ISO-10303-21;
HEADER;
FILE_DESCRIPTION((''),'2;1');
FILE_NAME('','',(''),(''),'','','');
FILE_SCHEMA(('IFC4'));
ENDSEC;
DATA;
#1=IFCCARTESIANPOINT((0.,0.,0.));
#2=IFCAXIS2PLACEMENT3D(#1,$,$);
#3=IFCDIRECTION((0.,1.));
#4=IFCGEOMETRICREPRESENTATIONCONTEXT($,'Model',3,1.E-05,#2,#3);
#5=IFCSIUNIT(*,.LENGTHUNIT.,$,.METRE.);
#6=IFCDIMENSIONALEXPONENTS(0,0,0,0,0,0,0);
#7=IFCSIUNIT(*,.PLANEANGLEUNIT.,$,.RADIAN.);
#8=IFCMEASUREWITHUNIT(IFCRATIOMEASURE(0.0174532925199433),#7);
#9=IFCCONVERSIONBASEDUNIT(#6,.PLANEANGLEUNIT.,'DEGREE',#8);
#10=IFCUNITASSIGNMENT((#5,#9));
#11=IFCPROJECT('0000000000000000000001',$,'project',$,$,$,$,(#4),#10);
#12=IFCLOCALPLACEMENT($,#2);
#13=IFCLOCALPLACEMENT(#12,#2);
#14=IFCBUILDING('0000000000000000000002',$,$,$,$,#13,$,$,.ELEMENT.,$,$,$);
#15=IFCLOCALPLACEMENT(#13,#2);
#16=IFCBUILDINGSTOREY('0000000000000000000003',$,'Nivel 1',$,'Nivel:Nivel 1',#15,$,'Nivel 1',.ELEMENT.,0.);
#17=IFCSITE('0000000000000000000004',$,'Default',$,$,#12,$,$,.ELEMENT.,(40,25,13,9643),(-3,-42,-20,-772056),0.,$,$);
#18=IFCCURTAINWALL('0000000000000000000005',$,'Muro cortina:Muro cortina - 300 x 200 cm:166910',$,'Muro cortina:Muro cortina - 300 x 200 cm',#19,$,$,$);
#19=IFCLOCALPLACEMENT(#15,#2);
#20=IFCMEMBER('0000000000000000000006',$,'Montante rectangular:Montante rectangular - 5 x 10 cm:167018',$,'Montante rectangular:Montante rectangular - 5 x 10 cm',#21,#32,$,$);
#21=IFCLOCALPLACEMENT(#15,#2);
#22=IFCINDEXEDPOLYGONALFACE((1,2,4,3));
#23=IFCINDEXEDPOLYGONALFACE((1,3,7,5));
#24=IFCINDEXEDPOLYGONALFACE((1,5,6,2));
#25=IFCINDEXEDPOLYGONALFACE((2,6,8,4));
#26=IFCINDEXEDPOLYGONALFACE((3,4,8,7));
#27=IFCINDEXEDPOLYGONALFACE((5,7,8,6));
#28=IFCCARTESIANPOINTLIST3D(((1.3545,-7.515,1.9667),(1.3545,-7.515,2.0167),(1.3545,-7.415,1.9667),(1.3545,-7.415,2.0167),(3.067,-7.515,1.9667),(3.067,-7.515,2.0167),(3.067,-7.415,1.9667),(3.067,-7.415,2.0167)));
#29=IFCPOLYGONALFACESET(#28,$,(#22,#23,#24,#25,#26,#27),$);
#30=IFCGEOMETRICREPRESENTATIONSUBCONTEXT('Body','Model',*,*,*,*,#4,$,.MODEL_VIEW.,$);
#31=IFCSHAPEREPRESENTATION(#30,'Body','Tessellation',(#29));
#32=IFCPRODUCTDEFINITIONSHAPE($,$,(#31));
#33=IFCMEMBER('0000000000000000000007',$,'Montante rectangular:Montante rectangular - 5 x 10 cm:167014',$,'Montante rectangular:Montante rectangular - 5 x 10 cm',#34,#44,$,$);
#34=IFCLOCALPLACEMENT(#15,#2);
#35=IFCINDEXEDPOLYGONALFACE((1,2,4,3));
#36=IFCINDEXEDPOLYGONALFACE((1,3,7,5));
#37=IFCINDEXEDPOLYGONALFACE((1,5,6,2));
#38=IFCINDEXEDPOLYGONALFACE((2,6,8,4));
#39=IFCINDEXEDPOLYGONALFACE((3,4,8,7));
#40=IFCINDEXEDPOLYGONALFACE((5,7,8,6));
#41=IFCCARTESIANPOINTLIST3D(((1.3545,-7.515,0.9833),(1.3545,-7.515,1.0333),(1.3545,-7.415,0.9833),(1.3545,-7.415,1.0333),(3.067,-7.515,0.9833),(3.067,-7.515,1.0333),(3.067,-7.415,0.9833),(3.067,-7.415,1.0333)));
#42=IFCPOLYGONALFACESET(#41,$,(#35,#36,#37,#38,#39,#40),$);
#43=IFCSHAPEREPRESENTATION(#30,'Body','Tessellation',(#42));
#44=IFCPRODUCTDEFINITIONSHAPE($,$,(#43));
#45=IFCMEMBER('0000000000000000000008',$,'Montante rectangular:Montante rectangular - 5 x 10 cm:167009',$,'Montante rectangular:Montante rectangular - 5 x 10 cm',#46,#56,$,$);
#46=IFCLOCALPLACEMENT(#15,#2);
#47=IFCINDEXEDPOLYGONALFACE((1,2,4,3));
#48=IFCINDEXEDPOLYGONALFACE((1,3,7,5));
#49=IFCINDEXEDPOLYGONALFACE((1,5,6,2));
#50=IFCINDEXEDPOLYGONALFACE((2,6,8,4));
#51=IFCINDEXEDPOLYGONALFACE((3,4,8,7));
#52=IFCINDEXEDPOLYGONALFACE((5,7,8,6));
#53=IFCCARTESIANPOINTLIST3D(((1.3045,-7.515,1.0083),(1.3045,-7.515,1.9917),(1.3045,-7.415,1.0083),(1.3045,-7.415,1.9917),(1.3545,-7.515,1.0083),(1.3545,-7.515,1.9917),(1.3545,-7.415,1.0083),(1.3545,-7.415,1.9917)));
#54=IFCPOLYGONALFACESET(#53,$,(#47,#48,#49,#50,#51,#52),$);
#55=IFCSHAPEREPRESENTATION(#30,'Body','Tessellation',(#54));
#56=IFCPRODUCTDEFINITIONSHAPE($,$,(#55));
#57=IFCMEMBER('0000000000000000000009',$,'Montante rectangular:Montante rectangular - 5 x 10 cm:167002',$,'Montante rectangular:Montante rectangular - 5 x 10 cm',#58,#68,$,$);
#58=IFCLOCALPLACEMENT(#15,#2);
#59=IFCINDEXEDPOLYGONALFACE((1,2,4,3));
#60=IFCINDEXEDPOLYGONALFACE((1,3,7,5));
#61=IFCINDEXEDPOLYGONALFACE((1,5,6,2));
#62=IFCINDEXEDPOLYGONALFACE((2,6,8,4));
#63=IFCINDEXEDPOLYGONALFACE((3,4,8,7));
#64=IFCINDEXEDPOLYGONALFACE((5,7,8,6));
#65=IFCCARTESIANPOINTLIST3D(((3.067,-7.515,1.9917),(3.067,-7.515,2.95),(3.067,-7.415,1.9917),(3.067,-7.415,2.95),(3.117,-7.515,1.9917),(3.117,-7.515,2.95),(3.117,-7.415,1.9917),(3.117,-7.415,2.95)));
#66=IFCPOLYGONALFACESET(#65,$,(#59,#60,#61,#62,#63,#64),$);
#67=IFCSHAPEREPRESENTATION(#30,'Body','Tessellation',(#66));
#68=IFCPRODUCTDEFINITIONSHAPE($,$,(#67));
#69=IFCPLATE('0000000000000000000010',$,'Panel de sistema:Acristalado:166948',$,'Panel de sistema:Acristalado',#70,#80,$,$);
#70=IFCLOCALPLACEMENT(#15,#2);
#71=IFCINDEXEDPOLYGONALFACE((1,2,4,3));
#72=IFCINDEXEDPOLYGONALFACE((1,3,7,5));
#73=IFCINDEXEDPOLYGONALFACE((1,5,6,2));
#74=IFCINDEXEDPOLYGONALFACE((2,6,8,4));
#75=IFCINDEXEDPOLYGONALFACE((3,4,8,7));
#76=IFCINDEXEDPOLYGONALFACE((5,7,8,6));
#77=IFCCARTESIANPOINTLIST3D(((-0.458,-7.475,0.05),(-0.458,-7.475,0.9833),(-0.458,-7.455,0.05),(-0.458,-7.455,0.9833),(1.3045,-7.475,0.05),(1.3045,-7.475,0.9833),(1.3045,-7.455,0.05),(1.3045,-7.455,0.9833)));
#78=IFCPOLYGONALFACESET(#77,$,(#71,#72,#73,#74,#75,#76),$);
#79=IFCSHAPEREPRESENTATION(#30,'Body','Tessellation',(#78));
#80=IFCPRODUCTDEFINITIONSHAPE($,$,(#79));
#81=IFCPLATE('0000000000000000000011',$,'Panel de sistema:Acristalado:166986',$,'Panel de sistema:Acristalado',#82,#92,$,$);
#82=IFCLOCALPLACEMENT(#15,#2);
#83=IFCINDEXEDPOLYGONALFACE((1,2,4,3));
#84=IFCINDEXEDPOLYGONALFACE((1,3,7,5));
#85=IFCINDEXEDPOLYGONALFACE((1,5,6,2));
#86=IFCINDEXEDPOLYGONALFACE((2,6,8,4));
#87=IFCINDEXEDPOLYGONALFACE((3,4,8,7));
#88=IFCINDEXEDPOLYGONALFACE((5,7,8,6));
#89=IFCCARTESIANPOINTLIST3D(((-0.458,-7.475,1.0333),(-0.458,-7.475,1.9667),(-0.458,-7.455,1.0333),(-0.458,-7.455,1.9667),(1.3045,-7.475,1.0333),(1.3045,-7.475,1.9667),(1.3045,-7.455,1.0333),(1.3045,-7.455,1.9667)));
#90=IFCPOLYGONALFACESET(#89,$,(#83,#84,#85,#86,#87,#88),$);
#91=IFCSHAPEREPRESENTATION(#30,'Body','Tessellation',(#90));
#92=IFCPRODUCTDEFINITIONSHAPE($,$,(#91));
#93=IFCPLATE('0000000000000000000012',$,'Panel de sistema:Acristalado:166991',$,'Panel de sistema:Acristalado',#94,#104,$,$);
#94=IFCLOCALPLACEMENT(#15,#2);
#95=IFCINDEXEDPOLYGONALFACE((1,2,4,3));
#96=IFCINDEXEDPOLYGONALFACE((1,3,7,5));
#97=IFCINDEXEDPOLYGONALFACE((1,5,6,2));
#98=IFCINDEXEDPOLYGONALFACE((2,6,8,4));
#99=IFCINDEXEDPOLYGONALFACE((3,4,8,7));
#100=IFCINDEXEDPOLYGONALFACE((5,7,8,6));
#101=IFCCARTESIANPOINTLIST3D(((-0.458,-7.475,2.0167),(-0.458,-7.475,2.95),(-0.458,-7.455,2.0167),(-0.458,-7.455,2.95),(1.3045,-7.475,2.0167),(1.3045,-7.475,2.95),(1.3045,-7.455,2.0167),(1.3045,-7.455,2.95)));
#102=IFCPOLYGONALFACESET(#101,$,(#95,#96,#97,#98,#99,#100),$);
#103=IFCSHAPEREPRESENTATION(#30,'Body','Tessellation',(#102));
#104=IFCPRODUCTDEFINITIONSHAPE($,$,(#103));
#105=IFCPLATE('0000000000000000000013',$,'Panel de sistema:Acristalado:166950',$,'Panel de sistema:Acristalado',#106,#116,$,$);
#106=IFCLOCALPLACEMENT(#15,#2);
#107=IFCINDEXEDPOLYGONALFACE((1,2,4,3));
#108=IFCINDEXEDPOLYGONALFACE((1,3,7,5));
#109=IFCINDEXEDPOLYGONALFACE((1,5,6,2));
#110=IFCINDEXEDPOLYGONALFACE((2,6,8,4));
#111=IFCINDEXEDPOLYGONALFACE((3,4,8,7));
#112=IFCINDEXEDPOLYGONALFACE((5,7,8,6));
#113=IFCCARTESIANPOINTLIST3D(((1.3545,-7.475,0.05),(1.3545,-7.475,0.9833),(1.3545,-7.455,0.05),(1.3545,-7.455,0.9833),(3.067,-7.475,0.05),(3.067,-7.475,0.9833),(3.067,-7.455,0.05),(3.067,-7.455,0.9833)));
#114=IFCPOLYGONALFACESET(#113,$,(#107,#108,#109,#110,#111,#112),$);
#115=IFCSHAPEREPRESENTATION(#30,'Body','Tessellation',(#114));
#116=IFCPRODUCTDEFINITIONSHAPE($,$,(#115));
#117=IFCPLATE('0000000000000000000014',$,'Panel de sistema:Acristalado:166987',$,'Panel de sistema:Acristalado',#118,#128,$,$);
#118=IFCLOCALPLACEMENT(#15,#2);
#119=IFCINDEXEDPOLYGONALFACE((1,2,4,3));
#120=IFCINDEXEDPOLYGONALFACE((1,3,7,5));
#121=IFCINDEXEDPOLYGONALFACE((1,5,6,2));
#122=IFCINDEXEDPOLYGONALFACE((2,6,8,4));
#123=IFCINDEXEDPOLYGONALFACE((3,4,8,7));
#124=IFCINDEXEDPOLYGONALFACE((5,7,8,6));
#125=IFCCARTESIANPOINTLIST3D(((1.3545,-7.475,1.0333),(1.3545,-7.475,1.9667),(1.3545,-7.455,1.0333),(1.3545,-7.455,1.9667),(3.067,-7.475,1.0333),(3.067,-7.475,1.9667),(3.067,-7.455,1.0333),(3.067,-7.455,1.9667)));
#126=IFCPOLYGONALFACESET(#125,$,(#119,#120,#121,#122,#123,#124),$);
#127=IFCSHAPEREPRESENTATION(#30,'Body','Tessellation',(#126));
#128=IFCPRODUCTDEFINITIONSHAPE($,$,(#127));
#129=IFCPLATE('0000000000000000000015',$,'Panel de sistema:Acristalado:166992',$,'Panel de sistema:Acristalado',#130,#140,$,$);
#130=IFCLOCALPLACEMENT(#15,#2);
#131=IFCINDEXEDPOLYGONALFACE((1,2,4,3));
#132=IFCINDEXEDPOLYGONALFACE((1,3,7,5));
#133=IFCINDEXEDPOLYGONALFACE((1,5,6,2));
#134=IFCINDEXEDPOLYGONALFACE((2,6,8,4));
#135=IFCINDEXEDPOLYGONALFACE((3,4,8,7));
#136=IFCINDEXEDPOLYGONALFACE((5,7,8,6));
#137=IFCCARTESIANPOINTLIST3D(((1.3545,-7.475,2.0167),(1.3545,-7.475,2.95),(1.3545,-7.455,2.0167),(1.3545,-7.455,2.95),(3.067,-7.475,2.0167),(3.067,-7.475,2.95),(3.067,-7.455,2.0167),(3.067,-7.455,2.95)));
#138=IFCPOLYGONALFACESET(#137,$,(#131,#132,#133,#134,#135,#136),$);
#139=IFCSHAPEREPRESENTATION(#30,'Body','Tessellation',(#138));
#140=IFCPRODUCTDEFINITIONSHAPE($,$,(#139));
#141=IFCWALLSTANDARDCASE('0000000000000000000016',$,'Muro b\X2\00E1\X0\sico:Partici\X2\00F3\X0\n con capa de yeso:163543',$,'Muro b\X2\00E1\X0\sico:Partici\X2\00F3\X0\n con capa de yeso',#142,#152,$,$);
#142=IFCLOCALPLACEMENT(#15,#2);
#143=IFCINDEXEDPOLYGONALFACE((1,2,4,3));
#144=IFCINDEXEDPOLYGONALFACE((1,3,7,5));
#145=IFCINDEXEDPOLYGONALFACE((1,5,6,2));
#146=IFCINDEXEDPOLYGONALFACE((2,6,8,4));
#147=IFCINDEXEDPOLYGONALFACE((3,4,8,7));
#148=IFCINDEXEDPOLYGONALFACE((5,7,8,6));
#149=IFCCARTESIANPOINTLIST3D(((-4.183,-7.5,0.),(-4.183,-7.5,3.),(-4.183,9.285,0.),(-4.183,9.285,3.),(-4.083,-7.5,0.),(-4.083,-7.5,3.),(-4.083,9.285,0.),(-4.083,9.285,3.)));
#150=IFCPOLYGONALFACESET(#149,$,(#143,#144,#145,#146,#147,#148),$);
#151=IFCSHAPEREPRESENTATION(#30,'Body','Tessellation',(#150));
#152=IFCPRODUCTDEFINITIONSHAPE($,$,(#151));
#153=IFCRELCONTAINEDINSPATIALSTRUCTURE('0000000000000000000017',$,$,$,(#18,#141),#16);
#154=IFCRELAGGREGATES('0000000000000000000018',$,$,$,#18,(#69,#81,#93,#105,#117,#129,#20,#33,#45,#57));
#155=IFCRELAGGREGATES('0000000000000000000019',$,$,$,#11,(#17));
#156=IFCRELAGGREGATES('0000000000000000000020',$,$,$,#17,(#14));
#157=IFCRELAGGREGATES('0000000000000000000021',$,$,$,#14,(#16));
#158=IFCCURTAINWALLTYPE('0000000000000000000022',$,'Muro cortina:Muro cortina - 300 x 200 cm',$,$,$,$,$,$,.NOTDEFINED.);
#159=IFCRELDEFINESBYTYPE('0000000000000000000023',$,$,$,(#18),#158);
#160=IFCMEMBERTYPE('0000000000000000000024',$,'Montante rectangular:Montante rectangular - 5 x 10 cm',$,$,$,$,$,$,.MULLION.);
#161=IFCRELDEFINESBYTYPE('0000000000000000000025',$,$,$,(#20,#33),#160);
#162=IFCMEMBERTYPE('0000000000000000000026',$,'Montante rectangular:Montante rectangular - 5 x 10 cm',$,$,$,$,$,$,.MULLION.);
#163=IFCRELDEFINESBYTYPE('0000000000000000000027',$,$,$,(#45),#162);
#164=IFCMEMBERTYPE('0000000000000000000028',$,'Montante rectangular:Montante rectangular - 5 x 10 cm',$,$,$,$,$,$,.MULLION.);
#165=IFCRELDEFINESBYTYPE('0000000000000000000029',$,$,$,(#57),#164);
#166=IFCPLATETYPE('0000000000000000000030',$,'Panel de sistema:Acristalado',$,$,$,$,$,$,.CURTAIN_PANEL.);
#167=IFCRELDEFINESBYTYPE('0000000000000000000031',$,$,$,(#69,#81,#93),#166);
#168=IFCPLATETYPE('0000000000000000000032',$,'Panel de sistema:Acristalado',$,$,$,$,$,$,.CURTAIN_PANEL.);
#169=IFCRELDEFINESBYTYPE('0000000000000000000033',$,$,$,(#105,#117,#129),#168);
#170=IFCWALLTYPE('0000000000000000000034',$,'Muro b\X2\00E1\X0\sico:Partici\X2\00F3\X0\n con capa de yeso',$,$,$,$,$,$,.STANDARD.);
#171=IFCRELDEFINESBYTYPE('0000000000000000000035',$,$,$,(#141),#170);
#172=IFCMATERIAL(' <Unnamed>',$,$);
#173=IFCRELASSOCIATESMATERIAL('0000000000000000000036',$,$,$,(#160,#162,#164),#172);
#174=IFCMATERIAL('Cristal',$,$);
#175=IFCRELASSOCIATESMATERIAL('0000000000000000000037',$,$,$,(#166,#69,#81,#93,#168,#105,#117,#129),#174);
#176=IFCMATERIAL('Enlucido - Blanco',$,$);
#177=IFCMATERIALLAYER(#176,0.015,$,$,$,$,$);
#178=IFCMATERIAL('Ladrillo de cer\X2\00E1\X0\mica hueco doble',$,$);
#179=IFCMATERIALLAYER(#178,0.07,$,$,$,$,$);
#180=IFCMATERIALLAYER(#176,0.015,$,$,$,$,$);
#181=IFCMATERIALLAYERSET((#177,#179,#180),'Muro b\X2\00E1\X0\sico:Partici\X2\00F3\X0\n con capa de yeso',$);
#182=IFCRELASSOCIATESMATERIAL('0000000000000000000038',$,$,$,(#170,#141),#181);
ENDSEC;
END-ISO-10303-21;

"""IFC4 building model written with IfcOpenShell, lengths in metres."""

from ifc_helpers import new_model, entity, si_unit, converted_unit, direction, frame, frame_2d, origin, origin_2d_with_axis, place, context, subcontext, project, spatial, rectangle, extrude, source, transform, mapped, material, layer, layer_set, layer_usage, type_object, type_shapes, element, aggregate, save


model = new_model("IFC4")

# Units and contexts
model_context = context("Model", 3, precision=1e-05, world=origin(), true_north=direction((0.0, 1.0)))
body_context = subcontext(model_context, "Body", "Model", "MODEL_VIEW")
ifc_project = project(units=[si_unit("LENGTHUNIT", "METRE"), converted_unit("PLANEANGLEUNIT", "DEGREE", entity("IfcRatioMeasure", 0.0174532925199433), si_unit("PLANEANGLEUNIT", "RADIAN"), dimensions=[0, 0, 0, 0, 0, 0, 0])], contexts=[model_context])

# Site, building, storey
site_placement = place(None, origin())
site = spatial("IfcSite", under=ifc_project, at=site_placement, Name="Default", CompositionType="ELEMENT", RefLatitude=(40, 25, 13, 9643), RefLongitude=(-3, -42, -20, -772056), RefElevation=0.0)
building_placement = place(site_placement, origin())
building = spatial("IfcBuilding", under=site, at=building_placement, CompositionType="ELEMENT")
storey_placement = place(building_placement, origin())
storey = spatial("IfcBuildingStorey", under=building, at=storey_placement, Name="Nivel 1", ObjectType="Nivel:Nivel 1", LongName="Nivel 1", CompositionType="ELEMENT", Elevation=0.0)

# Curtain wall, members, plates
curtain_wall_type = type_object("IfcCurtainWallType", Name="Muro cortina:Muro cortina - 300 x 200 cm", PredefinedType="NOTDEFINED")
curtain_wall_placement = place(storey_placement, origin())
curtain_wall = element("IfcCurtainWall", 1, at=curtain_wall_placement, inside=storey, type_object=curtain_wall_type, Name="Muro cortina:Muro cortina - 300 x 200 cm:166910", ObjectType="Muro cortina:Muro cortina - 300 x 200 cm")
ifc_material_1 = material(Name=" <Unnamed>")
member_type_1 = type_object("IfcMemberType", Name="Montante rectangular:Montante rectangular - 5 x 10 cm", PredefinedType="MULLION", material=ifc_material_1)
shared_shape_1 = source(origin(), body_context, "Body", "SweptSolid", [
    extrude(rectangle(XDim=0.1, YDim=0.05, at=origin_2d_with_axis()), frame((0.0, 0.0, -1.7125), z_axis=(0.0, 0.0, 1.0), x_axis=(0.0, -1.0, 0.0)), (0.0, 0.0, 1.0), 1.7125),
])
type_shapes(member_type_1, [shared_shape_1])
member_1_placement = place(storey_placement, frame((3.067, -7.465, 1.9917), z_axis=(1.0, 0.0, 0.0), x_axis=(0.0, 0.0, 1.0)))
member_1 = element("IfcMember", 2, at=member_1_placement, type_object=member_type_1, Name="Montante rectangular:Montante rectangular - 5 x 10 cm:167018", ObjectType="Montante rectangular:Montante rectangular - 5 x 10 cm", context=body_context, shape_type="MappedRepresentation", body=[
    mapped(shared_shape_1, transform((0.0, 0.0, 0.0), scale=1.0)),
])
member_2_placement = place(storey_placement, frame((3.067, -7.465, 1.0083), z_axis=(1.0, 0.0, 0.0), x_axis=(0.0, 0.0, 1.0)))
member_2 = element("IfcMember", 3, at=member_2_placement, type_object=member_type_1, Name="Montante rectangular:Montante rectangular - 5 x 10 cm:167014", ObjectType="Montante rectangular:Montante rectangular - 5 x 10 cm", context=body_context, shape_type="MappedRepresentation", body=[
    mapped(shared_shape_1, transform((0.0, 0.0, 0.0), scale=1.0)),
])
member_type_2 = type_object("IfcMemberType", Name="Montante rectangular:Montante rectangular - 5 x 10 cm", PredefinedType="MULLION", material=ifc_material_1)
shared_shape_2 = source(origin(), body_context, "Body", "SweptSolid", [
    extrude(rectangle(XDim=0.1, YDim=0.05, at=origin_2d_with_axis()), frame((0.0, 0.0, -0.9833), z_axis=(0.0, 0.0, 1.0), x_axis=(0.0, -1.0, 0.0)), (0.0, 0.0, 1.0), 0.9833),
])
type_shapes(member_type_2, [shared_shape_2])
member_3_placement = place(storey_placement, frame((1.3295, -7.465, 1.0083), z_axis=(0.0, 0.0, -1.0), x_axis=(1.0, 0.0, 0.0)))
member_3 = element("IfcMember", 4, at=member_3_placement, type_object=member_type_2, Name="Montante rectangular:Montante rectangular - 5 x 10 cm:167009", ObjectType="Montante rectangular:Montante rectangular - 5 x 10 cm", context=body_context, shape_type="MappedRepresentation", body=[
    mapped(shared_shape_2, transform((0.0, 0.0, 0.0), scale=1.0)),
])
member_type_3 = type_object("IfcMemberType", Name="Montante rectangular:Montante rectangular - 5 x 10 cm", PredefinedType="MULLION", material=ifc_material_1)
shared_shape_3 = source(origin(), body_context, "Body", "SweptSolid", [
    extrude(rectangle(XDim=0.1, YDim=0.05, at=origin_2d_with_axis()), frame((-0.025, 0.0, -0.9583), z_axis=(0.0, 0.0, 1.0), x_axis=(0.0, -1.0, 0.0)), (0.0, 0.0, 1.0), 0.9583),
])
type_shapes(member_type_3, [shared_shape_3])
member_4_placement = place(storey_placement, frame((3.117, -7.465, 1.9917), z_axis=(0.0, 0.0, -1.0), x_axis=(1.0, 0.0, 0.0)))
member_4 = element("IfcMember", 5, at=member_4_placement, type_object=member_type_3, Name="Montante rectangular:Montante rectangular - 5 x 10 cm:167002", ObjectType="Montante rectangular:Montante rectangular - 5 x 10 cm", context=body_context, shape_type="MappedRepresentation", body=[
    mapped(shared_shape_3, transform((0.0, 0.0, 0.0), scale=1.0)),
])
ifc_material_2 = material(Name="Cristal")
plate_type_1 = type_object("IfcPlateType", Name="Panel de sistema:Acristalado", PredefinedType="CURTAIN_PANEL", material=ifc_material_2)
shared_shape_4 = source(origin(), body_context, "Body", "SweptSolid", [
    extrude(rectangle(XDim=0.02, YDim=1.7625, at=origin_2d_with_axis()), frame((0.0, 0.0, 0.0), z_axis=(0.0, 0.0, 1.0), x_axis=(0.0, 1.0, 0.0)), (0.0, 0.0, 1.0), 0.9333),
])
type_shapes(plate_type_1, [shared_shape_4])
plate_1_placement = place(curtain_wall_placement, frame((0.4232, -7.465, 0.05)))
plate_1 = element("IfcPlate", 6, at=plate_1_placement, type_object=plate_type_1, material=ifc_material_2, Name="Panel de sistema:Acristalado:166948", ObjectType="Panel de sistema:Acristalado", context=body_context, shape_type="MappedRepresentation", body=[
    mapped(shared_shape_4, transform((0.0, 0.0, 0.0), scale=1.0)),
])
plate_2_placement = place(curtain_wall_placement, frame((0.4232, -7.465, 1.0333)))
plate_2 = element("IfcPlate", 7, at=plate_2_placement, type_object=plate_type_1, material=ifc_material_2, Name="Panel de sistema:Acristalado:166986", ObjectType="Panel de sistema:Acristalado", context=body_context, shape_type="MappedRepresentation", body=[
    mapped(shared_shape_4, transform((0.0, 0.0, 0.0), scale=1.0)),
])
plate_3_placement = place(curtain_wall_placement, frame((0.4232, -7.465, 2.0167)))
plate_3 = element("IfcPlate", 8, at=plate_3_placement, type_object=plate_type_1, material=ifc_material_2, Name="Panel de sistema:Acristalado:166991", ObjectType="Panel de sistema:Acristalado", context=body_context, shape_type="MappedRepresentation", body=[
    mapped(shared_shape_4, transform((0.0, 0.0, 0.0), scale=1.0)),
])
plate_type_2 = type_object("IfcPlateType", Name="Panel de sistema:Acristalado", PredefinedType="CURTAIN_PANEL", material=ifc_material_2)
shared_shape_5 = source(origin(), body_context, "Body", "SweptSolid", [
    extrude(rectangle(XDim=0.02, YDim=1.7125, at=origin_2d_with_axis()), frame((0.0, 0.0, 0.0), z_axis=(0.0, 0.0, 1.0), x_axis=(0.0, 1.0, 0.0)), (0.0, 0.0, 1.0), 0.9333),
])
type_shapes(plate_type_2, [shared_shape_5])
plate_4_placement = place(curtain_wall_placement, frame((2.2107, -7.465, 0.05)))
plate_4 = element("IfcPlate", 9, at=plate_4_placement, type_object=plate_type_2, material=ifc_material_2, Name="Panel de sistema:Acristalado:166950", ObjectType="Panel de sistema:Acristalado", context=body_context, shape_type="MappedRepresentation", body=[
    mapped(shared_shape_5, transform((0.0, 0.0, 0.0), scale=1.0)),
])
plate_5_placement = place(curtain_wall_placement, frame((2.2107, -7.465, 1.0333)))
plate_5 = element("IfcPlate", 10, at=plate_5_placement, type_object=plate_type_2, material=ifc_material_2, Name="Panel de sistema:Acristalado:166987", ObjectType="Panel de sistema:Acristalado", context=body_context, shape_type="MappedRepresentation", body=[
    mapped(shared_shape_5, transform((0.0, 0.0, 0.0), scale=1.0)),
])
plate_6_placement = place(curtain_wall_placement, frame((2.2107, -7.465, 2.0167)))
plate_6 = element("IfcPlate", 11, at=plate_6_placement, type_object=plate_type_2, material=ifc_material_2, Name="Panel de sistema:Acristalado:166992", ObjectType="Panel de sistema:Acristalado", context=body_context, shape_type="MappedRepresentation", body=[
    mapped(shared_shape_5, transform((0.0, 0.0, 0.0), scale=1.0)),
])
aggregate(curtain_wall, [plate_1, plate_2, plate_3, plate_4, plate_5, plate_6, member_1, member_2, member_3, member_4])

# Wall
ifc_material_3 = material(Name="Enlucido - Blanco")
ifc_layer_1 = layer(ifc_material_3, 0.015)
ifc_material_4 = material(Name="Ladrillo de cerámica hueco doble")
ifc_layer_2 = layer(ifc_material_4, 0.07)
ifc_layer_3 = layer(ifc_material_3, 0.015)
ifc_layer_set = layer_set([ifc_layer_1, ifc_layer_2, ifc_layer_3], Name="Muro básico:Partición con capa de yeso")
ifc_layer_usage = layer_usage(ifc_layer_set, "AXIS2", "NEGATIVE", 0.05)
wall_type = type_object("IfcWallType", Name="Muro básico:Partición con capa de yeso", PredefinedType="STANDARD", material=ifc_layer_set)
wall_placement = place(storey_placement, frame((-4.133, -7.5, 0.0), z_axis=(0.0, 0.0, 1.0), x_axis=(0.0, 1.0, 0.0)))
element("IfcWallStandardCase", 12, at=wall_placement, inside=storey, type_object=wall_type, material=ifc_layer_usage, Name="Muro básico:Partición con capa de yeso:163543", ObjectType="Muro básico:Partición con capa de yeso", context=body_context, shape_type="SweptSolid", body=[
    extrude(rectangle(XDim=16.785, YDim=0.1, at=frame_2d((8.3925, 0.0), x_axis=(-1.0, 0.0))), origin(), (0.0, 0.0, 1.0), 3.0),
])

save(model, "model.ifc")
